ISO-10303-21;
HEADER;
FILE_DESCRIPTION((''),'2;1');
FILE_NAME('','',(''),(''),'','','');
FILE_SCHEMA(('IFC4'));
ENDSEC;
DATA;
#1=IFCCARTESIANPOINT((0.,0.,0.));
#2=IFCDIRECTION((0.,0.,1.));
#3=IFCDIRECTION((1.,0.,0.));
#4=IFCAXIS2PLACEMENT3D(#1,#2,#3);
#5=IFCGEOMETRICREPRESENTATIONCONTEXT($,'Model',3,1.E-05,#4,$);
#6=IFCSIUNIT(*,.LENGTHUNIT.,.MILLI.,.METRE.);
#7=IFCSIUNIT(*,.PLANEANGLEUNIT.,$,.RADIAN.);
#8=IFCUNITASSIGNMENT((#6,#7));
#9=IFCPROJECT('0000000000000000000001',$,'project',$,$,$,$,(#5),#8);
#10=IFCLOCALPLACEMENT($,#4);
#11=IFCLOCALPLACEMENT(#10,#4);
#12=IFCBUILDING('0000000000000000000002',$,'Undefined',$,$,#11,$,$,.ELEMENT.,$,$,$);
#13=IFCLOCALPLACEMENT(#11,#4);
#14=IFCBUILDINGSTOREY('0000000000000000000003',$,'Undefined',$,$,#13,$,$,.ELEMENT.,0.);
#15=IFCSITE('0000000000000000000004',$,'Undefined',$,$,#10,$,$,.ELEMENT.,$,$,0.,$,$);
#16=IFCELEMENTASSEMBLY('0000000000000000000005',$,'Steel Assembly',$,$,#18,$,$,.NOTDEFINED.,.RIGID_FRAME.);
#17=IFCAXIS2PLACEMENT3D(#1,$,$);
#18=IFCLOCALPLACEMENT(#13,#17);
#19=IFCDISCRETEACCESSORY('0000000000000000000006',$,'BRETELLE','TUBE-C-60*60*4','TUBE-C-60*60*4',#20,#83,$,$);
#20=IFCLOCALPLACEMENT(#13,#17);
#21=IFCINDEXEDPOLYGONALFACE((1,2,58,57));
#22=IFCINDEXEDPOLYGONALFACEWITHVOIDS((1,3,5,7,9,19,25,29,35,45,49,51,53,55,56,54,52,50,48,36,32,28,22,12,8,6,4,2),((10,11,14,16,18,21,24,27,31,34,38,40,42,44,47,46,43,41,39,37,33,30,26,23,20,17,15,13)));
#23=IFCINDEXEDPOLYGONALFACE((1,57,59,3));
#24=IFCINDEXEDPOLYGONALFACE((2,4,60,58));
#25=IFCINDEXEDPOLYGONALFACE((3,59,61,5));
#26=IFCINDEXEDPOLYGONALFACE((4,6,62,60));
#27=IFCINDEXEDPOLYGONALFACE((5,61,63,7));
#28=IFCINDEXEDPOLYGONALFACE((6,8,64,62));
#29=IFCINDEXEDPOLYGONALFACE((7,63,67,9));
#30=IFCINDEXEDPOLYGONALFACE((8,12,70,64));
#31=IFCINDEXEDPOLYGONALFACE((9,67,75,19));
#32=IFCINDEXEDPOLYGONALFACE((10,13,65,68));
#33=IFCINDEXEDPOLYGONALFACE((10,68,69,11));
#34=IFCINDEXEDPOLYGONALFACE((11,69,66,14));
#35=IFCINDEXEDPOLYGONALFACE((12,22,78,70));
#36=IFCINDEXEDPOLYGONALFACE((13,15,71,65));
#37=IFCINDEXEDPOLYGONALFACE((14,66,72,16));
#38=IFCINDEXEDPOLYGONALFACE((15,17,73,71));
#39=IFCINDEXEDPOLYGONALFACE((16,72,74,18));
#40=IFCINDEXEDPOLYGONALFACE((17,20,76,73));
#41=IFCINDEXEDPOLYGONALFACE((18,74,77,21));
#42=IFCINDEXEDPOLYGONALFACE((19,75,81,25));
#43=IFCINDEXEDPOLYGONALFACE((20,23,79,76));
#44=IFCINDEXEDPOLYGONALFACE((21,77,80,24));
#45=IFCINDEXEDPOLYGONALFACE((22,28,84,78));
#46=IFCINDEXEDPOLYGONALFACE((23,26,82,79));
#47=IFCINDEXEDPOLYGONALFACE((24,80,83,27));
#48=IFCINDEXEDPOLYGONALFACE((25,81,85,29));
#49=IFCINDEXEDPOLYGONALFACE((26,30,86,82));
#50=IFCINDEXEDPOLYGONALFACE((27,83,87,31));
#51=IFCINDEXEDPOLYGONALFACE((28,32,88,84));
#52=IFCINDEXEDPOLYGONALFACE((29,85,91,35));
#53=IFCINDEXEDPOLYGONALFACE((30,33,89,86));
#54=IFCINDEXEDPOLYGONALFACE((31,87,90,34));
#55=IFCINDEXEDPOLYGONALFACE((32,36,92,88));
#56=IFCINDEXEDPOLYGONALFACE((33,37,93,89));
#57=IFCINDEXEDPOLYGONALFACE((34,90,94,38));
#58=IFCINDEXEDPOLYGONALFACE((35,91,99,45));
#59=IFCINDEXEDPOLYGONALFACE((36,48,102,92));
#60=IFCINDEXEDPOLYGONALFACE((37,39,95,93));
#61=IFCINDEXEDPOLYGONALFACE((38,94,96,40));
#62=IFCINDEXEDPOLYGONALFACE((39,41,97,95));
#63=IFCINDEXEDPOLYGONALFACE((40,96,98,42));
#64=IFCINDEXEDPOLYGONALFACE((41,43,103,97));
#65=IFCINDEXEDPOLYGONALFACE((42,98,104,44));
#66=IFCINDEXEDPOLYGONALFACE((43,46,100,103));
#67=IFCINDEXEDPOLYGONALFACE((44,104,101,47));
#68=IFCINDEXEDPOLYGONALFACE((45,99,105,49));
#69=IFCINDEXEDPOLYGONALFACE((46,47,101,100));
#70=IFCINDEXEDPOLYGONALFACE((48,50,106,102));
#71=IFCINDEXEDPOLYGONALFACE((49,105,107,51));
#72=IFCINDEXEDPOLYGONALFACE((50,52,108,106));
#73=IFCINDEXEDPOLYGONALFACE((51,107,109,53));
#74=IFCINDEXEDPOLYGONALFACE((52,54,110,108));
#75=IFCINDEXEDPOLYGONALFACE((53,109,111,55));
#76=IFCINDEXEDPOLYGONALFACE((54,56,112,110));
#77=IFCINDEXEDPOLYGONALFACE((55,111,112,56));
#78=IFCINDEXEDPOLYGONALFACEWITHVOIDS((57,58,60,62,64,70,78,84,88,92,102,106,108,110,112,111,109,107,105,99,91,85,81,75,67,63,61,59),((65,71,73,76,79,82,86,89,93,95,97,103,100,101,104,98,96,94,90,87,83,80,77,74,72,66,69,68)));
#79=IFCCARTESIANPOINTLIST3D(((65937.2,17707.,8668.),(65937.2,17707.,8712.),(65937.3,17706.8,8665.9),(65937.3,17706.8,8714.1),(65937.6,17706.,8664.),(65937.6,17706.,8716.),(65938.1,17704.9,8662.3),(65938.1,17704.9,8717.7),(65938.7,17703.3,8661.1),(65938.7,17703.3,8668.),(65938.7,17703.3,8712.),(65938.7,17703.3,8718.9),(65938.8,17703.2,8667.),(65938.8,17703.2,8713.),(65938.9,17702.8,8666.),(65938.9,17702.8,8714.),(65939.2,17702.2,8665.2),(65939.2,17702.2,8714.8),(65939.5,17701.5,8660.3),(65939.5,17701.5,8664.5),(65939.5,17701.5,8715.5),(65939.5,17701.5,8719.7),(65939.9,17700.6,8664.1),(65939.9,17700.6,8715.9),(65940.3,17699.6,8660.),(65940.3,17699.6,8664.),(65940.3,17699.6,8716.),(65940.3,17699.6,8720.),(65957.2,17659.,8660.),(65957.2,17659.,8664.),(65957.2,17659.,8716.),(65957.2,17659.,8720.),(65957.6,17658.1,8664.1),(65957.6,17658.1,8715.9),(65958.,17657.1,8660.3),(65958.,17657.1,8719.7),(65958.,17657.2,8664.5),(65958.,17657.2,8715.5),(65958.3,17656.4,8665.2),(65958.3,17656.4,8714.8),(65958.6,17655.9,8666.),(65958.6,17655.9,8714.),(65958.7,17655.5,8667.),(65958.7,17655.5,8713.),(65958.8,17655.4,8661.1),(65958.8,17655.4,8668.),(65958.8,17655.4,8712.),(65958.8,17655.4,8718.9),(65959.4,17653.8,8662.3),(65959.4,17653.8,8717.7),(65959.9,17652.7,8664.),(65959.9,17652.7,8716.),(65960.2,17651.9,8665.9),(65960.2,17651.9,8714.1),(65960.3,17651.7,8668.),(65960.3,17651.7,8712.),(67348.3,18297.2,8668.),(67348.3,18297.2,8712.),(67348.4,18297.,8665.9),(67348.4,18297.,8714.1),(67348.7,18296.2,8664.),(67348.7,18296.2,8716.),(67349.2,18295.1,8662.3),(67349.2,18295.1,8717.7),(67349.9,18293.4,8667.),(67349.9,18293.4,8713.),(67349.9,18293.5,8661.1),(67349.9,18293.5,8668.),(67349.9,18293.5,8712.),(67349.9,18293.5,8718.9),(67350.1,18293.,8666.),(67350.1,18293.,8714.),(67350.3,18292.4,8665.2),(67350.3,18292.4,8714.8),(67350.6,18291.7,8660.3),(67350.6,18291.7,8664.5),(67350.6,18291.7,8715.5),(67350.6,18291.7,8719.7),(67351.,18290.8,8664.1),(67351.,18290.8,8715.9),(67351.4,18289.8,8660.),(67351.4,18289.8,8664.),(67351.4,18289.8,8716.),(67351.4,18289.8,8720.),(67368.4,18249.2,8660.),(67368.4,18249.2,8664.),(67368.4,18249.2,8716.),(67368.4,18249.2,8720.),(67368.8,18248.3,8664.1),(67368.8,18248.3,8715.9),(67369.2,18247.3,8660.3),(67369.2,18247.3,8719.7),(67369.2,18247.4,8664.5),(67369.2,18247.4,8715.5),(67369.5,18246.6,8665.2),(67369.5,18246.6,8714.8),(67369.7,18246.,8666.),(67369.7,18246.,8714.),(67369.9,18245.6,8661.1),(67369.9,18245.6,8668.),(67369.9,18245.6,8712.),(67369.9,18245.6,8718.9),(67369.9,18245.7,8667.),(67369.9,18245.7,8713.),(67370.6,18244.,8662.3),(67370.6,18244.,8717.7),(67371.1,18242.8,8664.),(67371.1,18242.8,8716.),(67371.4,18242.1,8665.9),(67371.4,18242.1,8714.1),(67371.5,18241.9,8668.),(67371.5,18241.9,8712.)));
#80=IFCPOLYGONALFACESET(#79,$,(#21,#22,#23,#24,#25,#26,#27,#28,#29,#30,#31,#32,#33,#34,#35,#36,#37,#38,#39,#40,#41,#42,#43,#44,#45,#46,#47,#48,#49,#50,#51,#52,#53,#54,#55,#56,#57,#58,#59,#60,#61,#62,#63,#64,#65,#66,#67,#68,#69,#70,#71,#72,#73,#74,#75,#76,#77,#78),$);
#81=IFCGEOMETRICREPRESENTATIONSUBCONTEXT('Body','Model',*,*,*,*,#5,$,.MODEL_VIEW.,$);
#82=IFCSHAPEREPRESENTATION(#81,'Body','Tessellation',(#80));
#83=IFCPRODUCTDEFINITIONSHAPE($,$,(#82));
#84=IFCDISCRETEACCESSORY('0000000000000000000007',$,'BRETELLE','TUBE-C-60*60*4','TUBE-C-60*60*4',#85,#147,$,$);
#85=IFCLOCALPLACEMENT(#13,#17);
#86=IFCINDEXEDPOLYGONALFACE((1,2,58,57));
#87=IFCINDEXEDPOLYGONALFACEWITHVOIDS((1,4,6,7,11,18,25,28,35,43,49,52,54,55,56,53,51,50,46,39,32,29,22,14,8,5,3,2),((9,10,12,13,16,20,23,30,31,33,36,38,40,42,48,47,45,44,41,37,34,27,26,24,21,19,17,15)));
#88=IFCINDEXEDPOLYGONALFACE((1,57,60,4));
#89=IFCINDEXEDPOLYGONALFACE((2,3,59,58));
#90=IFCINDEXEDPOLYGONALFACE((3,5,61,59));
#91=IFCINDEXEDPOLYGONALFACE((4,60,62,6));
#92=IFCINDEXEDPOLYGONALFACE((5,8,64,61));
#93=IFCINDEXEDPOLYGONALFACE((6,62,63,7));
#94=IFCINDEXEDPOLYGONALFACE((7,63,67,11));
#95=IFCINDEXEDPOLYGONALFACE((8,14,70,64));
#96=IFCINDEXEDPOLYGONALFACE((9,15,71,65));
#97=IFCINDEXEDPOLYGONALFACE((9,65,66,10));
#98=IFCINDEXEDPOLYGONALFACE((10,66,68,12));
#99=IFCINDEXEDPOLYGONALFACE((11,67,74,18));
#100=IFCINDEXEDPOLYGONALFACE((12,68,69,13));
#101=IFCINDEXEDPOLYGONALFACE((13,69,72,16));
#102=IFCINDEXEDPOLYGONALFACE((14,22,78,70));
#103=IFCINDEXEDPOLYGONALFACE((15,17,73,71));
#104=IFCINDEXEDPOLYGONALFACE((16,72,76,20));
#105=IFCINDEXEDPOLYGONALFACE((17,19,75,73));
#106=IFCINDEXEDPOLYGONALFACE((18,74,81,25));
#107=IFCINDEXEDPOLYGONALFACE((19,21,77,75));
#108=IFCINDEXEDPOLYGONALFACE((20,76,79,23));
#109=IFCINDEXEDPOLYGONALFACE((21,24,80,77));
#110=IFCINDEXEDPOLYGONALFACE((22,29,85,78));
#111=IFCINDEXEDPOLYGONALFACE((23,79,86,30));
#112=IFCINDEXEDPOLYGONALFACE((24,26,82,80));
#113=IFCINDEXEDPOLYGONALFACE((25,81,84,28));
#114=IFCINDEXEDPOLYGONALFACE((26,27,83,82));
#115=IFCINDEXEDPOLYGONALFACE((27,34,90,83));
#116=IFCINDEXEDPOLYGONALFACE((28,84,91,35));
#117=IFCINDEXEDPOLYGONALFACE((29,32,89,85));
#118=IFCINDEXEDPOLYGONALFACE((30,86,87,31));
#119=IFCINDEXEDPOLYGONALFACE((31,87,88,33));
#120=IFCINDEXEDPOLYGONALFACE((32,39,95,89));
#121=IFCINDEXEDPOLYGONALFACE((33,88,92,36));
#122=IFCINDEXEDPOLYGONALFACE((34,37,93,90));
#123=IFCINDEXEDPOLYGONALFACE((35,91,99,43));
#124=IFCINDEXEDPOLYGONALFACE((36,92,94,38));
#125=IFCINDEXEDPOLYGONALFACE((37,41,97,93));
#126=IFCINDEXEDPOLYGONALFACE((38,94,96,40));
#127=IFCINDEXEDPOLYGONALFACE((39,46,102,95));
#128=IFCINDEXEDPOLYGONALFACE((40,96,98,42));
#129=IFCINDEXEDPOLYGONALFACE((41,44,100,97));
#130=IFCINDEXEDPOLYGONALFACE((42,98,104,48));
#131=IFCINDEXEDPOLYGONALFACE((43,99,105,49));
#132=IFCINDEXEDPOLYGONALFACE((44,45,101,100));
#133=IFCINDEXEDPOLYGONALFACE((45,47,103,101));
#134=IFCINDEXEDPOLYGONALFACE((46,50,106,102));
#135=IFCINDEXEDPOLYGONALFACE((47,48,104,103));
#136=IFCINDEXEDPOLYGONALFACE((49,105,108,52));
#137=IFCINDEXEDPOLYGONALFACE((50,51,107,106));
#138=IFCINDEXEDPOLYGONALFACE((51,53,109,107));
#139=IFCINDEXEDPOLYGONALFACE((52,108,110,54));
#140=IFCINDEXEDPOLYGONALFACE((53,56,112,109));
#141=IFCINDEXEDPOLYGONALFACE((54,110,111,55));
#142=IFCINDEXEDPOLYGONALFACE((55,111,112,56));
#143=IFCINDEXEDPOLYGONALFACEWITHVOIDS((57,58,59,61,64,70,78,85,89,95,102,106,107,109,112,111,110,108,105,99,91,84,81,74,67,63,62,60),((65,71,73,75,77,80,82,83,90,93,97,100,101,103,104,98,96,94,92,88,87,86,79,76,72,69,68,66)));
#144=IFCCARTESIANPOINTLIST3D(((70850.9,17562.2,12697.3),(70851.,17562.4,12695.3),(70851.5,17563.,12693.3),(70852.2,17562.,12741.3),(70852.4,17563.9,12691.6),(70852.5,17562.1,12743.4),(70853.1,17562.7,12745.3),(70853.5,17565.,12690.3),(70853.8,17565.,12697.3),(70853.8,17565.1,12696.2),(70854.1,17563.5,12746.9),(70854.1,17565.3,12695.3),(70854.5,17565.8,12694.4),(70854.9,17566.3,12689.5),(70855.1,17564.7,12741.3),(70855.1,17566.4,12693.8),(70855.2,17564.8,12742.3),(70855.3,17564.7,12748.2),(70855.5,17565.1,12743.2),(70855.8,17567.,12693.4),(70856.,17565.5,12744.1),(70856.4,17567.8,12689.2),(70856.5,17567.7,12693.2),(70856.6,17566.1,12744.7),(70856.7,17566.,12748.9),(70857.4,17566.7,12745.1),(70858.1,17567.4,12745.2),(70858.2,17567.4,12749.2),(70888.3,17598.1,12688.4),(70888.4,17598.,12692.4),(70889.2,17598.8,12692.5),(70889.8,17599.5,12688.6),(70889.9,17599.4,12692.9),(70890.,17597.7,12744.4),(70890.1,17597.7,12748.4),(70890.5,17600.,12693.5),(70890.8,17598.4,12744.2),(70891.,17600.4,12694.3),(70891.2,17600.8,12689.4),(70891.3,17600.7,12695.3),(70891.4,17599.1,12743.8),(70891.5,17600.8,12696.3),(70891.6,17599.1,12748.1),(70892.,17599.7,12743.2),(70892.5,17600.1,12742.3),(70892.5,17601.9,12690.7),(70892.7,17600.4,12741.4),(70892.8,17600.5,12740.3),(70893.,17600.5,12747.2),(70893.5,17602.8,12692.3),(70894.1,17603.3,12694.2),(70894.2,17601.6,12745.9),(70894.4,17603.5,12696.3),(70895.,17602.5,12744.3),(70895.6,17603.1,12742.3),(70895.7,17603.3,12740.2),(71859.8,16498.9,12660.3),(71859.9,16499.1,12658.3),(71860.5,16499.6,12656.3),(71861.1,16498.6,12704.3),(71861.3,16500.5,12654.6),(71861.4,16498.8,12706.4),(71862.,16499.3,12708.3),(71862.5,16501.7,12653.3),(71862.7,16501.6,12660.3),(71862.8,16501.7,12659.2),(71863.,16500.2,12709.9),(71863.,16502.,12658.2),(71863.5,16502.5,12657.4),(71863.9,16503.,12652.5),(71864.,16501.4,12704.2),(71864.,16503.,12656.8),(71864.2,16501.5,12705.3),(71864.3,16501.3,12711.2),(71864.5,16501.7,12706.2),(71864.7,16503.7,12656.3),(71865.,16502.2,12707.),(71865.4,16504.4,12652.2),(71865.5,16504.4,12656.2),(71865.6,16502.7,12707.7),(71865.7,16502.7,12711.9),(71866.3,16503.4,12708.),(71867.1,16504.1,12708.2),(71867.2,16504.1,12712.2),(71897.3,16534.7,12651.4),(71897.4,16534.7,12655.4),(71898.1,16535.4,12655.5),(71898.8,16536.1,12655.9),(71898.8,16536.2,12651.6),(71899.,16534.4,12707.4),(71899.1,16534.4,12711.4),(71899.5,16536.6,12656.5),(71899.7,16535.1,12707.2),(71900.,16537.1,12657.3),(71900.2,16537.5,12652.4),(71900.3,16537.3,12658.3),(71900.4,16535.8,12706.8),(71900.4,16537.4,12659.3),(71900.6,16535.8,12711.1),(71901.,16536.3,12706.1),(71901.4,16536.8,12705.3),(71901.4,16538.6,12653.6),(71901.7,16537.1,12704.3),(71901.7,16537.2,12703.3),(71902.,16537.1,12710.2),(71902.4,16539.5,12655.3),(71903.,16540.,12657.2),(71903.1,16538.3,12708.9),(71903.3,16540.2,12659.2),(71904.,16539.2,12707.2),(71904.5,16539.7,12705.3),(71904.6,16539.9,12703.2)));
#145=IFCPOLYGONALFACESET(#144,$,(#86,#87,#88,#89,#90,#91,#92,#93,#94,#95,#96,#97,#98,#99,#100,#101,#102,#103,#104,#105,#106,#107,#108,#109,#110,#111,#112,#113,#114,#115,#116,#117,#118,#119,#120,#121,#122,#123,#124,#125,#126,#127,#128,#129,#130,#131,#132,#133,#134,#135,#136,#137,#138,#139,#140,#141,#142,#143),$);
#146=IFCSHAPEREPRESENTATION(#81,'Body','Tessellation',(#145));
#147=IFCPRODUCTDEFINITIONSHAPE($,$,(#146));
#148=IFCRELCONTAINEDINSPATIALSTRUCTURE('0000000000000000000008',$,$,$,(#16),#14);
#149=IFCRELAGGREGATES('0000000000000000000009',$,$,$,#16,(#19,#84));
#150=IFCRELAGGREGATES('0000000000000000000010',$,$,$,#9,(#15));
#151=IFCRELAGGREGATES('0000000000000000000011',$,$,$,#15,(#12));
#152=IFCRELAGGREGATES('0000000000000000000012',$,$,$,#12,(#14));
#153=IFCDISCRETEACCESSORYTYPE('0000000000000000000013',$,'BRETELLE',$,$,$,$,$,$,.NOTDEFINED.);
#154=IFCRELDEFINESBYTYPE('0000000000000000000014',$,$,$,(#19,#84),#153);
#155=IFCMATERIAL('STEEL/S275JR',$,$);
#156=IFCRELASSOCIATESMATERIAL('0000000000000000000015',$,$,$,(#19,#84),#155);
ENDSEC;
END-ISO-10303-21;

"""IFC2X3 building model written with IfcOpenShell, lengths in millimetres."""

from ifc_helpers import new_model, si_unit, frame, origin_with_axes, origin_2d_with_axis, place, context, subcontext, project, spatial, hollow_rectangle, extrude, material, type_object, element, aggregate, save


model = new_model("IFC2X3")

# Units and contexts
model_context = context("Model", 3, precision=1e-05, world=origin_with_axes())
body_context = subcontext(model_context, "Body", "Model", "MODEL_VIEW")
ifc_project = project(units=[si_unit("LENGTHUNIT", "METRE", prefix="MILLI"), si_unit("PLANEANGLEUNIT", "RADIAN")], contexts=[model_context])

# Site, building, storey
site_placement = place(None, origin_with_axes())
site = spatial("IfcSite", under=ifc_project, at=site_placement, Name="Undefined", CompositionType="ELEMENT", RefElevation=0.0)
building_placement = place(site_placement, origin_with_axes())
building = spatial("IfcBuilding", under=site, at=building_placement, Name="Undefined", CompositionType="ELEMENT")
storey_placement = place(building_placement, origin_with_axes())
storey = spatial("IfcBuildingStorey", under=building, at=storey_placement, Name="Undefined", CompositionType="ELEMENT", Elevation=0.0)

# Shared definitions
ifc_material = material(Name="STEEL/S275JR")

# Element assembly, discrete accessories
assembly_1_placement = place(storey_placement, origin_with_axes())
assembly_1 = element("IfcElementAssembly", 1, at=assembly_1_placement, inside=storey, Name="Steel Assembly", AssemblyPlace="NOTDEFINED", PredefinedType="RIGID_FRAME")
discrete_accessory_type_1 = type_object("IfcDiscreteAccessoryType", Name="BRETELLE")
discrete_accessory_1_placement = place(assembly_1_placement, frame((67359.9, 18269.6, 8690.0), z_axis=(-0.385849, 0.922562, 0.0), x_axis=(-0.922562, -0.385849, 0.0)))
discrete_accessory_1 = element("IfcDiscreteAccessory", 2, at=discrete_accessory_1_placement, type_object=discrete_accessory_type_1, material=ifc_material, Name="BRETELLE", Description="TUBE-C-60*60*4", ObjectType="TUBE-C-60*60*4", context=body_context, shape_type="SweptSolid", body=[
    extrude(hollow_rectangle(XDim=60.0, YDim=60.0, WallThickness=4.0, InnerFilletRadius=4.0, OuterFilletRadius=8.0, at=origin_2d_with_axis()), frame((1529.6, 0.0, 0.0), z_axis=(-1.0, 0.0, 0.0), x_axis=(0.0, -1.0, 0.0)), (0.0, 0.0, 1.0), 1529.6),
])
discrete_accessory_2_placement = place(assembly_1_placement, frame((70873.3, 17582.7, 12718.8), z_axis=(0.724985, 0.68853, -0.017961), x_axis=(0.688093, -0.725184, -0.025247)))
discrete_accessory_2 = element("IfcDiscreteAccessory", 3, at=discrete_accessory_2_placement, type_object=discrete_accessory_type_1, material=ifc_material, Name="BRETELLE", Description="TUBE-C-60*60*4", ObjectType="TUBE-C-60*60*4", context=body_context, shape_type="SweptSolid", body=[
    extrude(hollow_rectangle(XDim=60.0, YDim=60.0, WallThickness=4.0, InnerFilletRadius=4.0, OuterFilletRadius=8.0, at=origin_2d_with_axis()), frame((1466.3, 0.0, 0.0), z_axis=(-1.0, 0.0, 0.0), x_axis=(0.0, -1.0, 0.0)), (0.0, 0.0, 1.0), 1466.3),
])
aggregate(assembly_1, [discrete_accessory_1, discrete_accessory_2])

save(model, "model.ifc")
